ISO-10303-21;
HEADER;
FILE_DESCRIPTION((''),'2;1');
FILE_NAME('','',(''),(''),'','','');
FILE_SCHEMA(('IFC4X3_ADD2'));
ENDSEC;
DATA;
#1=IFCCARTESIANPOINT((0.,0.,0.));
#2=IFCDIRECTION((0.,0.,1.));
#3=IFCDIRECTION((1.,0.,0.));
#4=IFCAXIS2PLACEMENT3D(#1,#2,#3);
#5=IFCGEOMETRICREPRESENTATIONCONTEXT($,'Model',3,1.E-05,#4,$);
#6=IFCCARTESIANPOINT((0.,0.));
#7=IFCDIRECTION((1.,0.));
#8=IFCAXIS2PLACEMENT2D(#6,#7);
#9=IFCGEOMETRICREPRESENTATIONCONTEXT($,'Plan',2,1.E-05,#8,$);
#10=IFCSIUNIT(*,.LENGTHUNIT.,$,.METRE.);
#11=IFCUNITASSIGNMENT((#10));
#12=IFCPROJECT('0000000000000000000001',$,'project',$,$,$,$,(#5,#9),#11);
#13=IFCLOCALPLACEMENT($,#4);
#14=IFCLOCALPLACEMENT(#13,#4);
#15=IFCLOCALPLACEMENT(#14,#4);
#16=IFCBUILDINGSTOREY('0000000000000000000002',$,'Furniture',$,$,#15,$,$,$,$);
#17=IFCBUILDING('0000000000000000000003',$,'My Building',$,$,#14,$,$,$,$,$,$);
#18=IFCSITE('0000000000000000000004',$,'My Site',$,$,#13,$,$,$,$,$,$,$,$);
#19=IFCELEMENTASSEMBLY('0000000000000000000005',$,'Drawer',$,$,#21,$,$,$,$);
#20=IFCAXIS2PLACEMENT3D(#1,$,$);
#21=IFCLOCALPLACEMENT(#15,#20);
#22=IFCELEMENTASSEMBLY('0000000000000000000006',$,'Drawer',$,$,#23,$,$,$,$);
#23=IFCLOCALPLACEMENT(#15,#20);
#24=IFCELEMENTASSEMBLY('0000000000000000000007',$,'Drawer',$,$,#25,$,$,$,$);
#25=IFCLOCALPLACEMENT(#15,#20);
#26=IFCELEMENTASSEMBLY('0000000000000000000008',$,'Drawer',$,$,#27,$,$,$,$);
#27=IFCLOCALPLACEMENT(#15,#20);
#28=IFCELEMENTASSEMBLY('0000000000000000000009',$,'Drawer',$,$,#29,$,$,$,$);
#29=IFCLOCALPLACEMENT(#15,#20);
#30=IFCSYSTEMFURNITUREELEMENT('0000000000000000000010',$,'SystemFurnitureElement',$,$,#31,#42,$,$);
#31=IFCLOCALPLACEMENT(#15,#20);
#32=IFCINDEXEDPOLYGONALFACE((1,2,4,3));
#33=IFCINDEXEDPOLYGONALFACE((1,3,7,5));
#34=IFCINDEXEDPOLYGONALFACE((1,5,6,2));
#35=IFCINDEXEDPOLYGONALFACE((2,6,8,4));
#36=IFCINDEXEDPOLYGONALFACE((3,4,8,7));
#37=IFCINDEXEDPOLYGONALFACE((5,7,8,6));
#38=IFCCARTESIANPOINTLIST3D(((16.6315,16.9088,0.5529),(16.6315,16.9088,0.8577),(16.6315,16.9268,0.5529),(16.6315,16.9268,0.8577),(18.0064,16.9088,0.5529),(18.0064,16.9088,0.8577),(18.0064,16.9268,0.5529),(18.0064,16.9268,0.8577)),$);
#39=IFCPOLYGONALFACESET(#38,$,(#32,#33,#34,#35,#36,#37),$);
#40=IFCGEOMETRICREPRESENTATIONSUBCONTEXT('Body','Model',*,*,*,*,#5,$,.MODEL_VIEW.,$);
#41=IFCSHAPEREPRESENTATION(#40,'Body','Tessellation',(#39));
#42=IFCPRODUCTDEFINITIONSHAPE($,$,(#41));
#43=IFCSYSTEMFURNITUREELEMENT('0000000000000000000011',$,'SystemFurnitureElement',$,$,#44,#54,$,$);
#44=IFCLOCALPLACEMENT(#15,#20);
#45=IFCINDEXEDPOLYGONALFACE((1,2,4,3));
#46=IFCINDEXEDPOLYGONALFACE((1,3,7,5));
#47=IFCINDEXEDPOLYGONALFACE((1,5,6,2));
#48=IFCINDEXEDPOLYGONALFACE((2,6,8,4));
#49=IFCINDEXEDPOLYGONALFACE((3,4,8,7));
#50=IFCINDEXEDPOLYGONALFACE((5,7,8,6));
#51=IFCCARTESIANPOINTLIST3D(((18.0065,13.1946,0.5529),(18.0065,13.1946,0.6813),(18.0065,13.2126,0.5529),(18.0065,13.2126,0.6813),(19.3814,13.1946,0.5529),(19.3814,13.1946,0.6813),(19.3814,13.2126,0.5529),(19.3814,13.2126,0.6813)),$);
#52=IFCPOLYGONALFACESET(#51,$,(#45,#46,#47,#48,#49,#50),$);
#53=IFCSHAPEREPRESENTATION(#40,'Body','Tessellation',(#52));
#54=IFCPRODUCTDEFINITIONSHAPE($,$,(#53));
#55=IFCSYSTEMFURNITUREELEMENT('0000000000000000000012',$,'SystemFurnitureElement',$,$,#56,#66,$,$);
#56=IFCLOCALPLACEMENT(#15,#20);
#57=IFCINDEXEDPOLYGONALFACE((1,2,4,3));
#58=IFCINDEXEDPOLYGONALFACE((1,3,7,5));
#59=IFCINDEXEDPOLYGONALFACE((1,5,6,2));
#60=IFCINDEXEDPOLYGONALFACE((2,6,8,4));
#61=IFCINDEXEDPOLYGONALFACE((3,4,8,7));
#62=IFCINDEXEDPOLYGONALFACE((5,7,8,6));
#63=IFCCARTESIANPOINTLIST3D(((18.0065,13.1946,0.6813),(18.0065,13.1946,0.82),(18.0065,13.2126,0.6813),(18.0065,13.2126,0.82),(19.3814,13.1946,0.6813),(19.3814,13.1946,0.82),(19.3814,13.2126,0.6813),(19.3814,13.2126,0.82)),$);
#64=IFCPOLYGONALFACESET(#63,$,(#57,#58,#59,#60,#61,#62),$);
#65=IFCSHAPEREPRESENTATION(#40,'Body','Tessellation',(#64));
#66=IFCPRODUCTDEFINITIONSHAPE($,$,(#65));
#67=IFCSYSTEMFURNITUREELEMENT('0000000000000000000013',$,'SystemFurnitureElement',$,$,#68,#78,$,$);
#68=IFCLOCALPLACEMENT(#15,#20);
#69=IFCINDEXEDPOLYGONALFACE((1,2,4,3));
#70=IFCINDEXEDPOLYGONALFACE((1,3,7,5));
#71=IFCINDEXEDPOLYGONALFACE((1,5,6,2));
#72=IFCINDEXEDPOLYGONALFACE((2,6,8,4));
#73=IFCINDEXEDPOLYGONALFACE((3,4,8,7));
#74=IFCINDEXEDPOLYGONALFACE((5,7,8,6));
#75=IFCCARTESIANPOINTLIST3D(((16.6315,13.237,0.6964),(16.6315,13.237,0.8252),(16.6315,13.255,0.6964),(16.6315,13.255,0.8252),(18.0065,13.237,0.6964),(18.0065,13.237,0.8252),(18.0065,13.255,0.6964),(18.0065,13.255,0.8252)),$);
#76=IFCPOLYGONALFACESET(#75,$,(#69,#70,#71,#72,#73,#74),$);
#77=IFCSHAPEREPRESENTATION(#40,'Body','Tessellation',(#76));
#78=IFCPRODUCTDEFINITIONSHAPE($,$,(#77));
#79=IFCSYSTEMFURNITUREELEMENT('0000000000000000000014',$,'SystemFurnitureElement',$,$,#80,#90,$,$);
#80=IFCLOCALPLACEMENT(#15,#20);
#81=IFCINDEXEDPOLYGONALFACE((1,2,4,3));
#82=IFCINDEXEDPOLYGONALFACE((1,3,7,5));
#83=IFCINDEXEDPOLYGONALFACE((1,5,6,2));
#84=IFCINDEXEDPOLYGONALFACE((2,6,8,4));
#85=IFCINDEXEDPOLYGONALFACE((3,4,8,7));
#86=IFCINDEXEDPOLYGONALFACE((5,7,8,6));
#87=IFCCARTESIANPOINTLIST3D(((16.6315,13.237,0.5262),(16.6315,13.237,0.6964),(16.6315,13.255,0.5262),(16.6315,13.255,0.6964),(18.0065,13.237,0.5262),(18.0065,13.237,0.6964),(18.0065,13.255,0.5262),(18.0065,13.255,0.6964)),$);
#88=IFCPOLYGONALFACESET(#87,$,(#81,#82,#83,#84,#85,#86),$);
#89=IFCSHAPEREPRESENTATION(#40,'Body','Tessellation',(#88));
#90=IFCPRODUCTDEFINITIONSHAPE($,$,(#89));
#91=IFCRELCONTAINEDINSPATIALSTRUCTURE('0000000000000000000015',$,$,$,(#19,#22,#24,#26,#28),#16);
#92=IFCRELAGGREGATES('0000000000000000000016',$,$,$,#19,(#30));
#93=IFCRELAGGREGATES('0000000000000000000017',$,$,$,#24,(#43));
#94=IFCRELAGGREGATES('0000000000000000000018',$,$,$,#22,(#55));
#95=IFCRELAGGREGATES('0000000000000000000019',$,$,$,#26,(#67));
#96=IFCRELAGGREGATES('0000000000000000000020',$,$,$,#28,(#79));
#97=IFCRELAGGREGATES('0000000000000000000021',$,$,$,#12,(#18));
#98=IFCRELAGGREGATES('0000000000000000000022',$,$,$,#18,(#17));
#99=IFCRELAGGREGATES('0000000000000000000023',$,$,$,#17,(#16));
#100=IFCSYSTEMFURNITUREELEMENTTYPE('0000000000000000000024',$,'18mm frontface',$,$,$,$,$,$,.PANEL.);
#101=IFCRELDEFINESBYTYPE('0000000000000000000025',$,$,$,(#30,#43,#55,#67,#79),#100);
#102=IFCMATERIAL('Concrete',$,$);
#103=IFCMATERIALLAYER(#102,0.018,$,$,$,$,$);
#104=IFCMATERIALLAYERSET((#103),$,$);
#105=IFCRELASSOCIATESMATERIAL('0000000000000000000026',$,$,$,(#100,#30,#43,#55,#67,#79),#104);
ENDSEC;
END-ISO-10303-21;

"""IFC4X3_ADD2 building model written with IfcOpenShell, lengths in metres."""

from ifc_helpers import new_model, si_unit, frame, origin_with_axes, origin_2d_with_axis, place, context, subcontext, project, spatial, line, indexed_curve, outline, extrude, material, layer, layer_set, layer_usage, type_object, element, aggregate, save


model = new_model("IFC4X3_ADD2")

# Units and contexts
model_context = context("Model", 3, precision=1e-05, world=origin_with_axes())
plan_context = context("Plan", 2, precision=1e-05, world=origin_2d_with_axis())
body_context = subcontext(model_context, "Body", "Model", "MODEL_VIEW")
ifc_project = project(units=[si_unit("LENGTHUNIT", "METRE")], contexts=[model_context, plan_context])

# Site, building, storey
site_placement = place(None, origin_with_axes())
site = spatial("IfcSite", under=ifc_project, at=site_placement, Name="My Site")
building_placement = place(site_placement, origin_with_axes())
building = spatial("IfcBuilding", under=site, at=building_placement, Name="My Building")
storey_placement = place(building_placement, origin_with_axes())
storey = spatial("IfcBuildingStorey", under=building, at=storey_placement, Name="Furniture")

# Element assembly
assembly_1_placement = place(storey_placement, frame((16.6315, 16.9088, 0.5529), z_axis=(0.0, 0.0, 1.0), x_axis=(-1.0, 0.0, 0.0)))
assembly_1 = element("IfcElementAssembly", 1, at=assembly_1_placement, inside=storey, Name="Drawer")

# Element assembly
assembly_2_placement = place(storey_placement, frame((19.385, 13.2126, 0.6813), z_axis=(0.0, 0.0, 1.0), x_axis=(1.0, 0.0, 0.0)))
assembly_2 = element("IfcElementAssembly", 2, at=assembly_2_placement, inside=storey, Name="Drawer")

# Element assembly
assembly_3_placement = place(storey_placement, frame((19.3814, 13.2126, 0.5529), z_axis=(0.0, 0.0, 1.0), x_axis=(1.0, 0.0, 0.0)))
assembly_3 = element("IfcElementAssembly", 3, at=assembly_3_placement, inside=storey, Name="Drawer")

# Element assemblies
assembly_4_placement = place(storey_placement, frame((18.0065, 13.255, 0.6964), z_axis=(0.0, 0.0, 1.0), x_axis=(1.0, 0.0, 0.0)))
assembly_4 = element("IfcElementAssembly", 4, at=assembly_4_placement, inside=storey, Name="Drawer")
assembly_5_placement = place(storey_placement, frame((18.0065, 13.255, 0.5262), z_axis=(0.0, 0.0, 1.0), x_axis=(1.0, 0.0, 0.0)))
assembly_5 = element("IfcElementAssembly", 5, at=assembly_5_placement, inside=storey, Name="Drawer")

# System furniture elements
ifc_material_1 = material(Name="Concrete")
ifc_layer_1 = layer(ifc_material_1, 0.018)
ifc_layer_set_1 = layer_set([ifc_layer_1])
ifc_layer_usage_1 = layer_usage(ifc_layer_set_1, "AXIS2", "POSITIVE", 0.0)
system_furniture_element_type_1 = type_object("IfcSystemFurnitureElementType", Name="18mm frontface", PredefinedType="PANEL", material=ifc_layer_set_1)
system_furniture_element_1_placement = place(assembly_1_placement, frame((-1.375, -0.018, 0.0), z_axis=(0.0, 0.0, 1.0), x_axis=(1.0, 0.0, 0.0)))
system_furniture_element_1 = element("IfcSystemFurnitureElement", 6, at=system_furniture_element_1_placement, type_object=system_furniture_element_type_1, material=ifc_layer_usage_1, Name="SystemFurnitureElement", context=body_context, shape_type="SweptSolid", body=[
    extrude(outline(indexed_curve([(0.0, 0.0), (0.0, 0.018), (1.375, 0.018), (1.375, 0.0)], segments=[line(1, 2, 3, 4, 1)])), origin_with_axes(), (0.0, 0.0, 1.0), 0.3048),
])
aggregate(assembly_1, [system_furniture_element_1])
ifc_layer_usage_2 = layer_usage(ifc_layer_set_1, "AXIS2", "POSITIVE", 0.0)
system_furniture_element_2_placement = place(assembly_3_placement, frame((-1.375, -0.018, 0.0), z_axis=(0.0, 0.0, 1.0), x_axis=(1.0, 0.0, 0.0)))
system_furniture_element_2 = element("IfcSystemFurnitureElement", 7, at=system_furniture_element_2_placement, type_object=system_furniture_element_type_1, material=ifc_layer_usage_2, Name="SystemFurnitureElement", context=body_context, shape_type="SweptSolid", body=[
    extrude(outline(indexed_curve([(0.0, 0.0), (0.0, 0.018), (1.375, 0.018), (1.375, 0.0)], segments=[line(1, 2, 3, 4, 1)])), origin_with_axes(), (0.0, 0.0, 1.0), 0.1284),
])
aggregate(assembly_3, [system_furniture_element_2])
ifc_layer_usage_3 = layer_usage(ifc_layer_set_1, "AXIS2", "POSITIVE", 0.0)
system_furniture_element_3_placement = place(assembly_2_placement, frame((-1.3785, -0.018, 0.0), z_axis=(0.0, 0.0, 1.0), x_axis=(1.0, 0.0, 0.0)))
system_furniture_element_3 = element("IfcSystemFurnitureElement", 8, at=system_furniture_element_3_placement, type_object=system_furniture_element_type_1, material=ifc_layer_usage_3, Name="SystemFurnitureElement", context=body_context, shape_type="SweptSolid", body=[
    extrude(outline(indexed_curve([(0.0, 0.0), (0.0, 0.018), (1.375, 0.018), (1.375, 0.0)], segments=[line(1, 2, 3, 4, 1)])), origin_with_axes(), (0.0, 0.0, 1.0), 0.1387),
])
aggregate(assembly_2, [system_furniture_element_3])
ifc_layer_usage_4 = layer_usage(ifc_layer_set_1, "AXIS2", "POSITIVE", 0.0)
system_furniture_element_4_placement = place(assembly_4_placement, frame((-1.375, -0.018, 0.0), z_axis=(0.0, 0.0, 1.0), x_axis=(1.0, 0.0, 0.0)))
system_furniture_element_4 = element("IfcSystemFurnitureElement", 9, at=system_furniture_element_4_placement, type_object=system_furniture_element_type_1, material=ifc_layer_usage_4, Name="SystemFurnitureElement", context=body_context, shape_type="SweptSolid", body=[
    extrude(outline(indexed_curve([(0.0, 0.0), (0.0, 0.018), (1.375, 0.018), (1.375, 0.0)], segments=[line(1, 2, 3, 4, 1)])), origin_with_axes(), (0.0, 0.0, 1.0), 0.1288),
])
aggregate(assembly_4, [system_furniture_element_4])
ifc_layer_usage_5 = layer_usage(ifc_layer_set_1, "AXIS2", "POSITIVE", 0.0)
system_furniture_element_5_placement = place(assembly_5_placement, frame((-1.375, -0.018, 0.0), z_axis=(0.0, 0.0, 1.0), x_axis=(1.0, 0.0, 0.0)))
system_furniture_element_5 = element("IfcSystemFurnitureElement", 10, at=system_furniture_element_5_placement, type_object=system_furniture_element_type_1, material=ifc_layer_usage_5, Name="SystemFurnitureElement", context=body_context, shape_type="SweptSolid", body=[
    extrude(outline(indexed_curve([(0.0, 0.0), (0.0, 0.018), (1.375, 0.018), (1.375, 0.0)], segments=[line(1, 2, 3, 4, 1)])), origin_with_axes(), (0.0, 0.0, 1.0), 0.1702),
])
aggregate(assembly_5, [system_furniture_element_5])

save(model, "model.ifc")
